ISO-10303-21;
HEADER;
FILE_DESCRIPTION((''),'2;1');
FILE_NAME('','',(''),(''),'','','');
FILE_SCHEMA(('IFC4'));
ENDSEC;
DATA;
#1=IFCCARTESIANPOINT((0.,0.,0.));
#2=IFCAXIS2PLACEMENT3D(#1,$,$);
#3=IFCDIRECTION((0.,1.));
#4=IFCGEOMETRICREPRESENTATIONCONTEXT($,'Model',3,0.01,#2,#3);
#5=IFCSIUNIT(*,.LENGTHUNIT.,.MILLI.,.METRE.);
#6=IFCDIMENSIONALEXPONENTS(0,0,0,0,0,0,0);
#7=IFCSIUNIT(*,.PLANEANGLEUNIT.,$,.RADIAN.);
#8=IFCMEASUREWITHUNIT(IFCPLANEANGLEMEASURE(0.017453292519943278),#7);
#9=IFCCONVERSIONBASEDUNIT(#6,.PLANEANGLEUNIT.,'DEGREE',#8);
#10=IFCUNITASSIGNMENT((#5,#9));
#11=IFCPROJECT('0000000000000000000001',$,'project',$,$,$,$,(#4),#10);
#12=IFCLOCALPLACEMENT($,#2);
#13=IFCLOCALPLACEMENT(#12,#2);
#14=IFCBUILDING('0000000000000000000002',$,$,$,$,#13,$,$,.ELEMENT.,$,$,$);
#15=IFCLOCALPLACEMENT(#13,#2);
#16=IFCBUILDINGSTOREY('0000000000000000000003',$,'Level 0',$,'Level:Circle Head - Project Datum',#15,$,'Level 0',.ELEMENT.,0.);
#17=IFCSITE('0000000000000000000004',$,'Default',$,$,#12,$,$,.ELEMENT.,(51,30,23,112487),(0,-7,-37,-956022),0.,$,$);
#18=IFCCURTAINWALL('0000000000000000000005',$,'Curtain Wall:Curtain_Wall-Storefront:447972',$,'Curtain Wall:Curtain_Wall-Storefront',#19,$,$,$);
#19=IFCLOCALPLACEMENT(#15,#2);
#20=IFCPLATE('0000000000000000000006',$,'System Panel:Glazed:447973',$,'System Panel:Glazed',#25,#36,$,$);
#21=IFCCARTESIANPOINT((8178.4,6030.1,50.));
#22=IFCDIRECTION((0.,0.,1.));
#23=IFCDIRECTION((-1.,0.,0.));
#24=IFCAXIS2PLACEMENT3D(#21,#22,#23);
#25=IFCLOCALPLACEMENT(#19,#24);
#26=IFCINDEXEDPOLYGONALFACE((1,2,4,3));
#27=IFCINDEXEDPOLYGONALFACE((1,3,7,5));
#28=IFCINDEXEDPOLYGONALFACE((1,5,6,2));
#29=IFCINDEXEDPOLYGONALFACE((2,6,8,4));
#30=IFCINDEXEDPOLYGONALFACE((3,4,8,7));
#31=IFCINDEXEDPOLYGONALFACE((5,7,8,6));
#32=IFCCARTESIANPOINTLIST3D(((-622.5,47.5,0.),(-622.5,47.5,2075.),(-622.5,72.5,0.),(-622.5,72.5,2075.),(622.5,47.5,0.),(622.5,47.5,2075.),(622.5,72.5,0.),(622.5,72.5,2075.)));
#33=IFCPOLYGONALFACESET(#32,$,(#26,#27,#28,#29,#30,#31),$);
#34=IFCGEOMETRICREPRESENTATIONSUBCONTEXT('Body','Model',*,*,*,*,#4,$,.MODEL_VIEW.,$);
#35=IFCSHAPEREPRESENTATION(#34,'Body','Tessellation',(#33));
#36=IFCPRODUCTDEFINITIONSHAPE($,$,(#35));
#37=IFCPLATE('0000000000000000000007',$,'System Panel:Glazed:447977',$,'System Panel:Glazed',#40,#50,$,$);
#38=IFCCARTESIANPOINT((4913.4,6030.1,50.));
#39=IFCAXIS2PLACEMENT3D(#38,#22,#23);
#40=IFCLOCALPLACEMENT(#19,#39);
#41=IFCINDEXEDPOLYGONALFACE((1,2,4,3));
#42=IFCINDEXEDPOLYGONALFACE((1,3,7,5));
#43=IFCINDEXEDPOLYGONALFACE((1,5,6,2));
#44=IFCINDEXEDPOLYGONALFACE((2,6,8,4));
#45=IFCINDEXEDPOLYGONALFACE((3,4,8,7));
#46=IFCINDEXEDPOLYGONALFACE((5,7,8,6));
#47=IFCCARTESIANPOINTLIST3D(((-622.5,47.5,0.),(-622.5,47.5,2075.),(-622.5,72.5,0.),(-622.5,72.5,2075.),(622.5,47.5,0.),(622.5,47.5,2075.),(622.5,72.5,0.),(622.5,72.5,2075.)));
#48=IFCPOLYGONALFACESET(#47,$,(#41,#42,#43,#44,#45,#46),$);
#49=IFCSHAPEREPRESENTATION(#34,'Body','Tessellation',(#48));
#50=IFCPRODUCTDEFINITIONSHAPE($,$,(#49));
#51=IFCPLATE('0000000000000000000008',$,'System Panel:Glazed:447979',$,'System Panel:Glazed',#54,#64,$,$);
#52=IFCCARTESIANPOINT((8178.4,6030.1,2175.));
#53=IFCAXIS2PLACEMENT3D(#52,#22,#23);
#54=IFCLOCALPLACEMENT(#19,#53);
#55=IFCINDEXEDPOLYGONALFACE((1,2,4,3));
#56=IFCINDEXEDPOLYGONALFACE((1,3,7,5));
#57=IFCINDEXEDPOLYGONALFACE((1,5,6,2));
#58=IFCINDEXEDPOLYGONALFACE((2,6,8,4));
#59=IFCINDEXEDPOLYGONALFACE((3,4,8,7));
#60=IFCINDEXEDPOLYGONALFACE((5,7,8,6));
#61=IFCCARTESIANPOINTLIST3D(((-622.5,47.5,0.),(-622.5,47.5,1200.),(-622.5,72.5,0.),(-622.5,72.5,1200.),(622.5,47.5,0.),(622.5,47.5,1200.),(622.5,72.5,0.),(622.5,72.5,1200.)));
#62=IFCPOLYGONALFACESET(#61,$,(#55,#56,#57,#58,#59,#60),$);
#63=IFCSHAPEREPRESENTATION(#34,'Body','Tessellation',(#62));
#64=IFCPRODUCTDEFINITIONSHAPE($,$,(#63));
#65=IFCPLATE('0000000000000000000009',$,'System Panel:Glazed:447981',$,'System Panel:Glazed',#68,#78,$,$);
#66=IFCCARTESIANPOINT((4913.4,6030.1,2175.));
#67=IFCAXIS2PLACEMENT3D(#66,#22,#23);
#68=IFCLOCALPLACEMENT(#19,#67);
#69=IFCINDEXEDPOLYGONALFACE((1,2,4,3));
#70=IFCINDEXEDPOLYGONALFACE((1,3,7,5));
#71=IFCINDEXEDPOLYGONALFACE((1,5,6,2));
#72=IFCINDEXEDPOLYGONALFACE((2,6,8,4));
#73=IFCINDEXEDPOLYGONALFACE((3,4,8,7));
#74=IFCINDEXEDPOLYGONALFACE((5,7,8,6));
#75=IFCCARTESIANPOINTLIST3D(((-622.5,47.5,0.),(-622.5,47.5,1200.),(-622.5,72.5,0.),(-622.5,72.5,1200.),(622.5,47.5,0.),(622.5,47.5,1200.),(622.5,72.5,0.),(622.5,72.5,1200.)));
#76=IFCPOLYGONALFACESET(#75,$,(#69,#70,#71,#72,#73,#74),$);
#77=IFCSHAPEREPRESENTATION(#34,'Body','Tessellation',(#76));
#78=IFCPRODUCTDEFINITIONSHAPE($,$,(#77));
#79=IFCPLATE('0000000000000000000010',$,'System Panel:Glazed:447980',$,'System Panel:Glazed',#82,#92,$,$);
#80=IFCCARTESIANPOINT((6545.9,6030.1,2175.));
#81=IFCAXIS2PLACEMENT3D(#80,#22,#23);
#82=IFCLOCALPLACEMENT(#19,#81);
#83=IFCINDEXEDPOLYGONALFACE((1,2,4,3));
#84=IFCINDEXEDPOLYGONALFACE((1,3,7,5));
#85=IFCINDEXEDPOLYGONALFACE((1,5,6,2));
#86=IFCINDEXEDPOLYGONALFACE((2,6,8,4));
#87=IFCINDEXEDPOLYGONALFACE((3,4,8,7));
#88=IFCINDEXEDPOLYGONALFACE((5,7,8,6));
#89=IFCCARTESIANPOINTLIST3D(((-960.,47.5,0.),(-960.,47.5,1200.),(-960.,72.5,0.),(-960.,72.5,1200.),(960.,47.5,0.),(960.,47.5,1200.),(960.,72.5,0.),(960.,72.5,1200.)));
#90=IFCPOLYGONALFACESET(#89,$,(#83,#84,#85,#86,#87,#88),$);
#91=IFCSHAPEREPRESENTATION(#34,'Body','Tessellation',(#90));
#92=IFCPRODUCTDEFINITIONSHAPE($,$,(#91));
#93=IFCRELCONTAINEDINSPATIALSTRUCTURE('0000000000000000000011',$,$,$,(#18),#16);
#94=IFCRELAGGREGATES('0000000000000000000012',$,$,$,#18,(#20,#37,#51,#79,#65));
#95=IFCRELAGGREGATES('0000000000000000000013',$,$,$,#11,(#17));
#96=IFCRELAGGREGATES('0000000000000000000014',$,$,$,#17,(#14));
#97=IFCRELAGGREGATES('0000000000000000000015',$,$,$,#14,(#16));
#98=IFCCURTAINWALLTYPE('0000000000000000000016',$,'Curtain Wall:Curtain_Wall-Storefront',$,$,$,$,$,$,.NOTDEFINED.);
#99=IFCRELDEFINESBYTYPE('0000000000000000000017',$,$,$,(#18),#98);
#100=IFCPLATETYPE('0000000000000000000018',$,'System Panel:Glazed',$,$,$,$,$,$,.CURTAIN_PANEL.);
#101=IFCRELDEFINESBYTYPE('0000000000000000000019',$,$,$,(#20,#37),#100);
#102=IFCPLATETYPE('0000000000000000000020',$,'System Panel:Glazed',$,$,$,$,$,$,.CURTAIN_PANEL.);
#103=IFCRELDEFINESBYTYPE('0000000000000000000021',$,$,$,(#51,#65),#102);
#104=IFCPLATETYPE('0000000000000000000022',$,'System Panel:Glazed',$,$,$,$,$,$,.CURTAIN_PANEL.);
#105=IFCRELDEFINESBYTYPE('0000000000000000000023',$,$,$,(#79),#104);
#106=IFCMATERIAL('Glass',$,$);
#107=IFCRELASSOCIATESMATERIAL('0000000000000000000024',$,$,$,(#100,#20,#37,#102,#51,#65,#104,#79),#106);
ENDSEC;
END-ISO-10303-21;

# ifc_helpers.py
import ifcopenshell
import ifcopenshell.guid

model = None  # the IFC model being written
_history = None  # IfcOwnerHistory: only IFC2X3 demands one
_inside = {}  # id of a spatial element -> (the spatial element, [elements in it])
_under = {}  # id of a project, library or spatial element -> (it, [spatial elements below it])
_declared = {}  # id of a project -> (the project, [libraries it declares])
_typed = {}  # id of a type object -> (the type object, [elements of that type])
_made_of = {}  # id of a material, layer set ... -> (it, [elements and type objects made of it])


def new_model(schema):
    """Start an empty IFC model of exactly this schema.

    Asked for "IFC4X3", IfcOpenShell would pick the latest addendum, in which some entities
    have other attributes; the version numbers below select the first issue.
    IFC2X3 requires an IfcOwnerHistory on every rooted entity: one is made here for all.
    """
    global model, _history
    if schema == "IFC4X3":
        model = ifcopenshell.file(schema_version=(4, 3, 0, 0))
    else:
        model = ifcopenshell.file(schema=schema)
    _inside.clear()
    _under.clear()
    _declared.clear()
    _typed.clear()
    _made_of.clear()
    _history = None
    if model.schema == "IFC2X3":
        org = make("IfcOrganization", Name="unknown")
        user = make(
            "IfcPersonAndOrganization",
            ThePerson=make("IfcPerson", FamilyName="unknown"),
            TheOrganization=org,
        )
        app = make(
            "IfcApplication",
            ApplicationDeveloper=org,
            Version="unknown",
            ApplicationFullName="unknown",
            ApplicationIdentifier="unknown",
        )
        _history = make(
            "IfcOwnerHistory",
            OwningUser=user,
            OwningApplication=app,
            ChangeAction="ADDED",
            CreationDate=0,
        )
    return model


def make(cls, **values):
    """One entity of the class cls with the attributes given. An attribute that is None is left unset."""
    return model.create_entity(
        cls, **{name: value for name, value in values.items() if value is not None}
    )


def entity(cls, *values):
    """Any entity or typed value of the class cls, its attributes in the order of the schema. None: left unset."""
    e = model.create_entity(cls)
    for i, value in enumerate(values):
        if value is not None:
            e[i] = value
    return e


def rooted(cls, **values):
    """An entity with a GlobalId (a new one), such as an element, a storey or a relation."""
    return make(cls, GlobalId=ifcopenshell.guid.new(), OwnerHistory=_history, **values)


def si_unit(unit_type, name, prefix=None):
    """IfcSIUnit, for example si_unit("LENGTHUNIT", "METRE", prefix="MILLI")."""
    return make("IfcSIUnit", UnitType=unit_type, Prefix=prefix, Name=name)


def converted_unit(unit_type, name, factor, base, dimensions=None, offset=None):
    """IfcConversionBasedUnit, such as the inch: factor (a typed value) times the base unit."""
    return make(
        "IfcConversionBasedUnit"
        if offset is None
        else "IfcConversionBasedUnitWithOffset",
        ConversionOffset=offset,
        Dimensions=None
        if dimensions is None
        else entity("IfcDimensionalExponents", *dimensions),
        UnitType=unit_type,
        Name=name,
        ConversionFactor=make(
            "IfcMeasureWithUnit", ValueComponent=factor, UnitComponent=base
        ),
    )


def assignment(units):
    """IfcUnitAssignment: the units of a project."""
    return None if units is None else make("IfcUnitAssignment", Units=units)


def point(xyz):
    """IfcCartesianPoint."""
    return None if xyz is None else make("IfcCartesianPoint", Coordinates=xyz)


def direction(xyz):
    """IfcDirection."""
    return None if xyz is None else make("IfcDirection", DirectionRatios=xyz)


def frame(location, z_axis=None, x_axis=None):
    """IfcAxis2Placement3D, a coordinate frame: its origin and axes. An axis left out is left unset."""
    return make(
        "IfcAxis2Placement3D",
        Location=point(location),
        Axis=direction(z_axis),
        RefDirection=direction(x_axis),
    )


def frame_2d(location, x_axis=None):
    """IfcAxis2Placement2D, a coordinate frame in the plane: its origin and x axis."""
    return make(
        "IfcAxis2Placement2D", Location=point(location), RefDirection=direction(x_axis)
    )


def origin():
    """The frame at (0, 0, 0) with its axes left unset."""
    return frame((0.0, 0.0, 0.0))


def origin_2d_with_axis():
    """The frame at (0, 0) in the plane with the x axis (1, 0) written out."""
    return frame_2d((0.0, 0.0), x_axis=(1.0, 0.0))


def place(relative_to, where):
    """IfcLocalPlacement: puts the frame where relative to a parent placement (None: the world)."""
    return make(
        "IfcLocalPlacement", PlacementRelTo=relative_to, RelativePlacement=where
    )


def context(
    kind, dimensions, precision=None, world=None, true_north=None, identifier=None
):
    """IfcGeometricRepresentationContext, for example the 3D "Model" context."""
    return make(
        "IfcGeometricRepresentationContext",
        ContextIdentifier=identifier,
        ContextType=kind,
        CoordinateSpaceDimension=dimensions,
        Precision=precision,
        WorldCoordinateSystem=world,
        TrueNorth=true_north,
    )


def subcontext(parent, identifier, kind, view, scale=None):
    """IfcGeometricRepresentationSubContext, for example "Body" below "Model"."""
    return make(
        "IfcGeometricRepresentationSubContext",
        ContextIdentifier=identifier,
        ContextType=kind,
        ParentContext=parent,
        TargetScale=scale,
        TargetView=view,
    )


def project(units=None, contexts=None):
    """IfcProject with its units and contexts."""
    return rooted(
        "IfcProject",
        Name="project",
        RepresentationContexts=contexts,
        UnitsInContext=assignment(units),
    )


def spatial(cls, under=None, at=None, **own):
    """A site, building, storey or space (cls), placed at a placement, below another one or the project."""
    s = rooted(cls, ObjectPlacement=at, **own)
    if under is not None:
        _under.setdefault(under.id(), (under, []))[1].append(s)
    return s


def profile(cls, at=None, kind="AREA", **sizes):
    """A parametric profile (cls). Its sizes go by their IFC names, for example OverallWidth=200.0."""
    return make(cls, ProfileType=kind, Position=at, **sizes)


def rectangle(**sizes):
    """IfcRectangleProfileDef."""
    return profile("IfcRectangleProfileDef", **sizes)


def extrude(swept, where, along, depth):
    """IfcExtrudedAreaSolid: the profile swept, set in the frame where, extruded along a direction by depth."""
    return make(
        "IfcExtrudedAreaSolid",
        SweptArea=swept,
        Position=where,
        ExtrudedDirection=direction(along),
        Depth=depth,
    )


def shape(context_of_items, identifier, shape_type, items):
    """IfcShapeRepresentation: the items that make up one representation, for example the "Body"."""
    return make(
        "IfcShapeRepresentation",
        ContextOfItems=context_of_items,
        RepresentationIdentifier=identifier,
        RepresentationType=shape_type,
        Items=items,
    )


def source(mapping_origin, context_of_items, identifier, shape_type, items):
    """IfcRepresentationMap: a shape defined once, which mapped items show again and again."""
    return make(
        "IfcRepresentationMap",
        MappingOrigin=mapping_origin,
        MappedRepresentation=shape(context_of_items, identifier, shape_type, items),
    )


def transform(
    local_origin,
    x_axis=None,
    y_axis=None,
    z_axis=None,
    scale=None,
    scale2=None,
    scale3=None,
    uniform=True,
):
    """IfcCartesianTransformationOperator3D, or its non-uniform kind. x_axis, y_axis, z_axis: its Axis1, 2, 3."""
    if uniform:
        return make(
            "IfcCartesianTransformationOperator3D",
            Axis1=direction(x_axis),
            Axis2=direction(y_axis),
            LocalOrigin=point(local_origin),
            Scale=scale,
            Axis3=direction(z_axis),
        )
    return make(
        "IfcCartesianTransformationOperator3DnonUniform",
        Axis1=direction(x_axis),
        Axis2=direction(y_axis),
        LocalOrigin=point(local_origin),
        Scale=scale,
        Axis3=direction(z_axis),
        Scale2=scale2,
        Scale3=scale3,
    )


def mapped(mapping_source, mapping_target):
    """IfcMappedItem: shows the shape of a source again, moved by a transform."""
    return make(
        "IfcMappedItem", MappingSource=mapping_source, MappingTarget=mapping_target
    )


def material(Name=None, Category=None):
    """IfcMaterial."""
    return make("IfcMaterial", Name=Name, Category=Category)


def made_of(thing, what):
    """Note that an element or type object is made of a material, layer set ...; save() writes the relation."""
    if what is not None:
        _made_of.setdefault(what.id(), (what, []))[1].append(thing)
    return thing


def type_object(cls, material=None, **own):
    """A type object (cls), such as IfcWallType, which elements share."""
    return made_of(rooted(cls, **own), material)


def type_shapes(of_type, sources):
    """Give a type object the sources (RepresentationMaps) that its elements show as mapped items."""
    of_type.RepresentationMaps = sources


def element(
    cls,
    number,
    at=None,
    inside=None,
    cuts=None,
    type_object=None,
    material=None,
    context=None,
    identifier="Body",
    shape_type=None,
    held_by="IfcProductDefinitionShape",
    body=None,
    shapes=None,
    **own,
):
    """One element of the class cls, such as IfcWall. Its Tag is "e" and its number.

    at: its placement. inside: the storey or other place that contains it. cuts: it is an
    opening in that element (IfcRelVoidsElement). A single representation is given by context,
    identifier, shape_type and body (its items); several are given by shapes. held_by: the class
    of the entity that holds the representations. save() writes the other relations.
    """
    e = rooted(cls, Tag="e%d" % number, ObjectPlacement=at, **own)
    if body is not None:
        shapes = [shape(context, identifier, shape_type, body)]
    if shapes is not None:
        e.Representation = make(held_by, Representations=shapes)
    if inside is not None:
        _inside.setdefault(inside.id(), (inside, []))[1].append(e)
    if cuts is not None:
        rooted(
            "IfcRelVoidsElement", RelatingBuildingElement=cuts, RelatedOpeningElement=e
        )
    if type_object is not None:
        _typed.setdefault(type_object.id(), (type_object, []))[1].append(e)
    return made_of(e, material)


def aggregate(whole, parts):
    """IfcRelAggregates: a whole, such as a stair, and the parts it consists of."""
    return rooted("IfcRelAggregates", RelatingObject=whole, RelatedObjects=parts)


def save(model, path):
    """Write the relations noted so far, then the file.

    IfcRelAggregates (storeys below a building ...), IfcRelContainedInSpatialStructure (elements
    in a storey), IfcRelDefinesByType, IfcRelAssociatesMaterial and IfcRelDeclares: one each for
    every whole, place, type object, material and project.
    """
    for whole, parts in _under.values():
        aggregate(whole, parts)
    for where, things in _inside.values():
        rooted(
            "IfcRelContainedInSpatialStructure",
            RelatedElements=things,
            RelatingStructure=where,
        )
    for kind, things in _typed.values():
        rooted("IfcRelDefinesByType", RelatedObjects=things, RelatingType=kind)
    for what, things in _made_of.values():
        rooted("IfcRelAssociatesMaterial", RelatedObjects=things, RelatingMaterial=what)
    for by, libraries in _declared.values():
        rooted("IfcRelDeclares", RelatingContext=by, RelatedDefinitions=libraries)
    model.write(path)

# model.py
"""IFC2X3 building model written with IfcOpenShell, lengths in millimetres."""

from ifc_helpers import new_model, entity, si_unit, converted_unit, direction, frame, origin, origin_2d_with_axis, place, context, subcontext, project, spatial, rectangle, extrude, source, transform, mapped, material, type_object, type_shapes, element, aggregate, save


model = new_model("IFC2X3")

# Units and contexts
model_context = context("Model", 3, precision=0.01, world=origin(), true_north=direction((0.0, 1.0)))
body_context = subcontext(model_context, "Body", "Model", "MODEL_VIEW")
ifc_project = project(units=[si_unit("LENGTHUNIT", "METRE", prefix="MILLI"), converted_unit("PLANEANGLEUNIT", "DEGREE", entity("IfcPlaneAngleMeasure", 0.017453292519943278), si_unit("PLANEANGLEUNIT", "RADIAN"), dimensions=[0, 0, 0, 0, 0, 0, 0])], contexts=[model_context])

# Site, building, storey
site_placement = place(None, origin())
site = spatial("IfcSite", under=ifc_project, at=site_placement, Name="Default", CompositionType="ELEMENT", RefLatitude=(51, 30, 23, 112487), RefLongitude=(0, -7, -37, -956022), RefElevation=0.0)
building_placement = place(site_placement, origin())
building = spatial("IfcBuilding", under=site, at=building_placement, CompositionType="ELEMENT")
storey_placement = place(building_placement, origin())
storey = spatial("IfcBuildingStorey", under=building, at=storey_placement, Name="Level 0", ObjectType="Level:Circle Head - Project Datum", LongName="Level 0", CompositionType="ELEMENT", Elevation=0.0)

# Curtain wall, plates
curtain_wall_type = type_object("IfcCurtainWallType", Name="Curtain Wall:Curtain_Wall-Storefront", PredefinedType="NOTDEFINED")
curtain_wall_placement = place(storey_placement, origin())
curtain_wall = element("IfcCurtainWall", 1, at=curtain_wall_placement, inside=storey, type_object=curtain_wall_type, Name="Curtain Wall:Curtain_Wall-Storefront:447972", ObjectType="Curtain Wall:Curtain_Wall-Storefront")
ifc_material_1 = material(Name="Glass")
plate_type_1 = type_object("IfcPlateType", Name="System Panel:Glazed", PredefinedType="CURTAIN_PANEL", material=ifc_material_1)
shared_shape_1 = source(origin(), body_context, "Body", "SweptSolid", [
    extrude(rectangle(XDim=25.0, YDim=1245.0, at=origin_2d_with_axis()), frame((0.0, 60.0, 0.0), z_axis=(0.0, 0.0, 1.0), x_axis=(0.0, 1.0, 0.0)), (0.0, 0.0, 1.0), 2075.0),
])
type_shapes(plate_type_1, [shared_shape_1])
plate_1_placement = place(curtain_wall_placement, frame((8178.4, 6030.1, 50.0), z_axis=(0.0, 0.0, 1.0), x_axis=(-1.0, 0.0, 0.0)))
plate_1 = element("IfcPlate", 2, at=plate_1_placement, type_object=plate_type_1, material=ifc_material_1, Name="System Panel:Glazed:447973", ObjectType="System Panel:Glazed", context=body_context, shape_type="MappedRepresentation", body=[
    mapped(shared_shape_1, transform((0.0, 0.0, 0.0), scale=1.0)),
])
plate_2_placement = place(curtain_wall_placement, frame((4913.4, 6030.1, 50.0), z_axis=(0.0, 0.0, 1.0), x_axis=(-1.0, 0.0, 0.0)))
plate_2 = element("IfcPlate", 3, at=plate_2_placement, type_object=plate_type_1, material=ifc_material_1, Name="System Panel:Glazed:447977", ObjectType="System Panel:Glazed", context=body_context, shape_type="MappedRepresentation", body=[
    mapped(shared_shape_1, transform((0.0, 0.0, 0.0), scale=1.0)),
])
plate_type_2 = type_object("IfcPlateType", Name="System Panel:Glazed", PredefinedType="CURTAIN_PANEL", material=ifc_material_1)
shared_shape_2 = source(origin(), body_context, "Body", "SweptSolid", [
    extrude(rectangle(XDim=25.0, YDim=1245.0, at=origin_2d_with_axis()), frame((0.0, 60.0, 0.0), z_axis=(0.0, 0.0, 1.0), x_axis=(0.0, 1.0, 0.0)), (0.0, 0.0, 1.0), 1200.0),
])
type_shapes(plate_type_2, [shared_shape_2])
plate_3_placement = place(curtain_wall_placement, frame((8178.4, 6030.1, 2175.0), z_axis=(0.0, 0.0, 1.0), x_axis=(-1.0, 0.0, 0.0)))
plate_3 = element("IfcPlate", 4, at=plate_3_placement, type_object=plate_type_2, material=ifc_material_1, Name="System Panel:Glazed:447979", ObjectType="System Panel:Glazed", context=body_context, shape_type="MappedRepresentation", body=[
    mapped(shared_shape_2, transform((0.0, 0.0, 0.0), scale=1.0)),
])
plate_4_placement = place(curtain_wall_placement, frame((4913.4, 6030.1, 2175.0), z_axis=(0.0, 0.0, 1.0), x_axis=(-1.0, 0.0, 0.0)))
plate_4 = element("IfcPlate", 5, at=plate_4_placement, type_object=plate_type_2, material=ifc_material_1, Name="System Panel:Glazed:447981", ObjectType="System Panel:Glazed", context=body_context, shape_type="MappedRepresentation", body=[
    mapped(shared_shape_2, transform((0.0, 0.0, 0.0), scale=1.0)),
])
plate_type_3 = type_object("IfcPlateType", Name="System Panel:Glazed", PredefinedType="CURTAIN_PANEL", material=ifc_material_1)
shared_shape_3 = source(origin(), body_context, "Body", "SweptSolid", [
    extrude(rectangle(XDim=25.0, YDim=1920.0, at=origin_2d_with_axis()), frame((0.0, 60.0, 0.0), z_axis=(0.0, 0.0, 1.0), x_axis=(0.0, 1.0, 0.0)), (0.0, 0.0, 1.0), 1200.0),
])
type_shapes(plate_type_3, [shared_shape_3])
plate_5_placement = place(curtain_wall_placement, frame((6545.9, 6030.1, 2175.0), z_axis=(0.0, 0.0, 1.0), x_axis=(-1.0, 0.0, 0.0)))
plate_5 = element("IfcPlate", 6, at=plate_5_placement, type_object=plate_type_3, material=ifc_material_1, Name="System Panel:Glazed:447980", ObjectType="System Panel:Glazed", context=body_context, shape_type="MappedRepresentation", body=[
    mapped(shared_shape_3, transform((0.0, 0.0, 0.0), scale=1.0)),
])
aggregate(curtain_wall, [plate_1, plate_2, plate_3, plate_5, plate_4])

save(model, "model.ifc")
